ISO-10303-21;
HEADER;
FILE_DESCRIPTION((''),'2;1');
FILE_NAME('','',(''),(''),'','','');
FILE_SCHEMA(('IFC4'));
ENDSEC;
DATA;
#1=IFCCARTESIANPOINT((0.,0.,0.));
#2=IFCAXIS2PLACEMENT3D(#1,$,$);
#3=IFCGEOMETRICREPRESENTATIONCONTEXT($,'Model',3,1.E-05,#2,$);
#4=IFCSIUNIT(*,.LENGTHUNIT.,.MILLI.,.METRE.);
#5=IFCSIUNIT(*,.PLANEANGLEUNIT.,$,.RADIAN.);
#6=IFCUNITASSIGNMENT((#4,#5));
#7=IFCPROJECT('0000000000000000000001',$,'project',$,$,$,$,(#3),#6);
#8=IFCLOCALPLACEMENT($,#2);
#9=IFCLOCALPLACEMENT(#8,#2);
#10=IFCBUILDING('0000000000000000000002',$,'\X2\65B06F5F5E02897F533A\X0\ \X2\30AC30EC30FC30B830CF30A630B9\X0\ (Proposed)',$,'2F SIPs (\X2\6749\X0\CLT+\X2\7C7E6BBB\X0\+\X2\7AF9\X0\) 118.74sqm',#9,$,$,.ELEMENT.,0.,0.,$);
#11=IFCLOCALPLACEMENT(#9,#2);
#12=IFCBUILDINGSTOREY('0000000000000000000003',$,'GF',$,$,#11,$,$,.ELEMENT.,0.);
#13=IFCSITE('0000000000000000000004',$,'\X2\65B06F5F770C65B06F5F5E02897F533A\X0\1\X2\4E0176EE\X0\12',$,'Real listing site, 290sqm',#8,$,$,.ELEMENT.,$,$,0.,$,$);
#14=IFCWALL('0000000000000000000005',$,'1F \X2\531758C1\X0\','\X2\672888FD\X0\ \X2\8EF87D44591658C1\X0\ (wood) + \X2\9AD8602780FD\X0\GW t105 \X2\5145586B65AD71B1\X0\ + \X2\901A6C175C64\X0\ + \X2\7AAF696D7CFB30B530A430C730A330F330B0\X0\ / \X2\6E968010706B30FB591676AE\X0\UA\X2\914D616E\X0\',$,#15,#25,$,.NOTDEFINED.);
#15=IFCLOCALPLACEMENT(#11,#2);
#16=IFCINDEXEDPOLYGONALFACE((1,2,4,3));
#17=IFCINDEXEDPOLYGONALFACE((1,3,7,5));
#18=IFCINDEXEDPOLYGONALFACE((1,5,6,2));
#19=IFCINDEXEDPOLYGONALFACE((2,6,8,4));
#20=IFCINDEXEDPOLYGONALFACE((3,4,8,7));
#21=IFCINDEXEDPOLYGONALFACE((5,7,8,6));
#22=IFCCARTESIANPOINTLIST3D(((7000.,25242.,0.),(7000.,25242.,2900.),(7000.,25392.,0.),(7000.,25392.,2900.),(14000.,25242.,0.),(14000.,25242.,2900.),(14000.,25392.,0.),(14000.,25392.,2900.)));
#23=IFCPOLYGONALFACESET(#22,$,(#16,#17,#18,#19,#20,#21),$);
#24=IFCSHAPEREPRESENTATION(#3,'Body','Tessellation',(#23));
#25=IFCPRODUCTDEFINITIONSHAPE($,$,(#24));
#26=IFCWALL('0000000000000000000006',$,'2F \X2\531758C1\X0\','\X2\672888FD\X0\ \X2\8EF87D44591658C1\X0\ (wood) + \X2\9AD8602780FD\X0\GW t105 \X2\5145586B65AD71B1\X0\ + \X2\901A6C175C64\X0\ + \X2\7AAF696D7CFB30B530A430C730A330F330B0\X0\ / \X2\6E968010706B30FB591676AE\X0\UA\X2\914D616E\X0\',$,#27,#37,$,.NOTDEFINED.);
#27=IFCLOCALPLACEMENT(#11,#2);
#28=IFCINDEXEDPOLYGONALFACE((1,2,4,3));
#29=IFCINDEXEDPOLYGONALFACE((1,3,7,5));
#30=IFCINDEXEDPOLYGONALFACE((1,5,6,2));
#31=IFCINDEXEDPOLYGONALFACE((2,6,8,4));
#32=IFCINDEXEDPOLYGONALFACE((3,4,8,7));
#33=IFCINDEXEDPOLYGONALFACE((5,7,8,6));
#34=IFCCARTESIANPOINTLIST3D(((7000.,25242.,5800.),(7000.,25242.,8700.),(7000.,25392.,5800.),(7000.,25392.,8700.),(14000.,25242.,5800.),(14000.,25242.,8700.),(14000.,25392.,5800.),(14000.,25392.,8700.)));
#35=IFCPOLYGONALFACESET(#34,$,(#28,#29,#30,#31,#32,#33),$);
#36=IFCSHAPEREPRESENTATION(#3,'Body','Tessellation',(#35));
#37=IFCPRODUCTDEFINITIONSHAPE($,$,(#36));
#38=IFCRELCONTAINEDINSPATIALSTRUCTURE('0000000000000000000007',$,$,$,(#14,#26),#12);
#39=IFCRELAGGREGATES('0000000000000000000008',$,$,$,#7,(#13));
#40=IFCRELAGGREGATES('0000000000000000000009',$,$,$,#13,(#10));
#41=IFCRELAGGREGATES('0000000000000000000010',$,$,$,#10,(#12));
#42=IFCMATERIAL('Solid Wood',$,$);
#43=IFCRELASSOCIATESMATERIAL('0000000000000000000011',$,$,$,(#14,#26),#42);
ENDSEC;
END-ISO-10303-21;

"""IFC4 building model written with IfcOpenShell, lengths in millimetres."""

from ifc_helpers import new_model, si_unit, frame, frame_2d, origin, place, context, project, spatial, rectangle, extrude, material, element, save


model = new_model("IFC4")

# Units and contexts
model_context = context("Model", 3, precision=1e-05, world=origin())
ifc_project = project(units=[si_unit("LENGTHUNIT", "METRE", prefix="MILLI"), si_unit("PLANEANGLEUNIT", "RADIAN")], contexts=[model_context])

# Site, building, storey
site_placement = place(None, origin())
site = spatial("IfcSite", under=ifc_project, at=site_placement, Name="新潟県新潟市西区1丁目12", ObjectType="Real listing site, 290sqm", CompositionType="ELEMENT", RefElevation=0.0)
building_placement = place(site_placement, origin())
building = spatial("IfcBuilding", under=site, at=building_placement, Name="新潟市西区 ガレージハウス (Proposed)", ObjectType="2F SIPs (杉CLT+籾殻+竹) 118.74sqm", CompositionType="ELEMENT", ElevationOfRefHeight=0.0, ElevationOfTerrain=0.0)
storey_placement = place(building_placement, origin())
storey = spatial("IfcBuildingStorey", under=building, at=storey_placement, Name="GF", CompositionType="ELEMENT", Elevation=0.0)

# Shared definitions
ifc_material_1 = material(Name="Solid Wood")

# Wall
wall_1_placement = place(storey_placement, frame((3500.0, 12621.0, 0.0)))
element("IfcWall", 1, at=wall_1_placement, inside=storey, material=ifc_material_1, Name="1F 北壁", Description="木製 軸組外壁 (wood) + 高性能GW t105 充填断熱 + 通気層 + 窯業系サイディング / 準耐火・外皮UA配慮", PredefinedType="NOTDEFINED", context=model_context, shape_type="SweptSolid", body=[
    extrude(rectangle(XDim=7000.0, YDim=150.0, at=frame_2d((3500.0, 75.0))), frame((3500.0, 12621.0, 0.0)), (0.0, 0.0, 1.0), 2900.0),
])

# Wall
wall_2_placement = place(storey_placement, frame((3500.0, 12621.0, 2900.0)))
element("IfcWall", 2, at=wall_2_placement, inside=storey, material=ifc_material_1, Name="2F 北壁", Description="木製 軸組外壁 (wood) + 高性能GW t105 充填断熱 + 通気層 + 窯業系サイディング / 準耐火・外皮UA配慮", PredefinedType="NOTDEFINED", context=model_context, shape_type="SweptSolid", body=[
    extrude(rectangle(XDim=7000.0, YDim=150.0, at=frame_2d((3500.0, 75.0))), frame((3500.0, 12621.0, 2900.0)), (0.0, 0.0, 1.0), 2900.0),
])

save(model, "model.ifc")
